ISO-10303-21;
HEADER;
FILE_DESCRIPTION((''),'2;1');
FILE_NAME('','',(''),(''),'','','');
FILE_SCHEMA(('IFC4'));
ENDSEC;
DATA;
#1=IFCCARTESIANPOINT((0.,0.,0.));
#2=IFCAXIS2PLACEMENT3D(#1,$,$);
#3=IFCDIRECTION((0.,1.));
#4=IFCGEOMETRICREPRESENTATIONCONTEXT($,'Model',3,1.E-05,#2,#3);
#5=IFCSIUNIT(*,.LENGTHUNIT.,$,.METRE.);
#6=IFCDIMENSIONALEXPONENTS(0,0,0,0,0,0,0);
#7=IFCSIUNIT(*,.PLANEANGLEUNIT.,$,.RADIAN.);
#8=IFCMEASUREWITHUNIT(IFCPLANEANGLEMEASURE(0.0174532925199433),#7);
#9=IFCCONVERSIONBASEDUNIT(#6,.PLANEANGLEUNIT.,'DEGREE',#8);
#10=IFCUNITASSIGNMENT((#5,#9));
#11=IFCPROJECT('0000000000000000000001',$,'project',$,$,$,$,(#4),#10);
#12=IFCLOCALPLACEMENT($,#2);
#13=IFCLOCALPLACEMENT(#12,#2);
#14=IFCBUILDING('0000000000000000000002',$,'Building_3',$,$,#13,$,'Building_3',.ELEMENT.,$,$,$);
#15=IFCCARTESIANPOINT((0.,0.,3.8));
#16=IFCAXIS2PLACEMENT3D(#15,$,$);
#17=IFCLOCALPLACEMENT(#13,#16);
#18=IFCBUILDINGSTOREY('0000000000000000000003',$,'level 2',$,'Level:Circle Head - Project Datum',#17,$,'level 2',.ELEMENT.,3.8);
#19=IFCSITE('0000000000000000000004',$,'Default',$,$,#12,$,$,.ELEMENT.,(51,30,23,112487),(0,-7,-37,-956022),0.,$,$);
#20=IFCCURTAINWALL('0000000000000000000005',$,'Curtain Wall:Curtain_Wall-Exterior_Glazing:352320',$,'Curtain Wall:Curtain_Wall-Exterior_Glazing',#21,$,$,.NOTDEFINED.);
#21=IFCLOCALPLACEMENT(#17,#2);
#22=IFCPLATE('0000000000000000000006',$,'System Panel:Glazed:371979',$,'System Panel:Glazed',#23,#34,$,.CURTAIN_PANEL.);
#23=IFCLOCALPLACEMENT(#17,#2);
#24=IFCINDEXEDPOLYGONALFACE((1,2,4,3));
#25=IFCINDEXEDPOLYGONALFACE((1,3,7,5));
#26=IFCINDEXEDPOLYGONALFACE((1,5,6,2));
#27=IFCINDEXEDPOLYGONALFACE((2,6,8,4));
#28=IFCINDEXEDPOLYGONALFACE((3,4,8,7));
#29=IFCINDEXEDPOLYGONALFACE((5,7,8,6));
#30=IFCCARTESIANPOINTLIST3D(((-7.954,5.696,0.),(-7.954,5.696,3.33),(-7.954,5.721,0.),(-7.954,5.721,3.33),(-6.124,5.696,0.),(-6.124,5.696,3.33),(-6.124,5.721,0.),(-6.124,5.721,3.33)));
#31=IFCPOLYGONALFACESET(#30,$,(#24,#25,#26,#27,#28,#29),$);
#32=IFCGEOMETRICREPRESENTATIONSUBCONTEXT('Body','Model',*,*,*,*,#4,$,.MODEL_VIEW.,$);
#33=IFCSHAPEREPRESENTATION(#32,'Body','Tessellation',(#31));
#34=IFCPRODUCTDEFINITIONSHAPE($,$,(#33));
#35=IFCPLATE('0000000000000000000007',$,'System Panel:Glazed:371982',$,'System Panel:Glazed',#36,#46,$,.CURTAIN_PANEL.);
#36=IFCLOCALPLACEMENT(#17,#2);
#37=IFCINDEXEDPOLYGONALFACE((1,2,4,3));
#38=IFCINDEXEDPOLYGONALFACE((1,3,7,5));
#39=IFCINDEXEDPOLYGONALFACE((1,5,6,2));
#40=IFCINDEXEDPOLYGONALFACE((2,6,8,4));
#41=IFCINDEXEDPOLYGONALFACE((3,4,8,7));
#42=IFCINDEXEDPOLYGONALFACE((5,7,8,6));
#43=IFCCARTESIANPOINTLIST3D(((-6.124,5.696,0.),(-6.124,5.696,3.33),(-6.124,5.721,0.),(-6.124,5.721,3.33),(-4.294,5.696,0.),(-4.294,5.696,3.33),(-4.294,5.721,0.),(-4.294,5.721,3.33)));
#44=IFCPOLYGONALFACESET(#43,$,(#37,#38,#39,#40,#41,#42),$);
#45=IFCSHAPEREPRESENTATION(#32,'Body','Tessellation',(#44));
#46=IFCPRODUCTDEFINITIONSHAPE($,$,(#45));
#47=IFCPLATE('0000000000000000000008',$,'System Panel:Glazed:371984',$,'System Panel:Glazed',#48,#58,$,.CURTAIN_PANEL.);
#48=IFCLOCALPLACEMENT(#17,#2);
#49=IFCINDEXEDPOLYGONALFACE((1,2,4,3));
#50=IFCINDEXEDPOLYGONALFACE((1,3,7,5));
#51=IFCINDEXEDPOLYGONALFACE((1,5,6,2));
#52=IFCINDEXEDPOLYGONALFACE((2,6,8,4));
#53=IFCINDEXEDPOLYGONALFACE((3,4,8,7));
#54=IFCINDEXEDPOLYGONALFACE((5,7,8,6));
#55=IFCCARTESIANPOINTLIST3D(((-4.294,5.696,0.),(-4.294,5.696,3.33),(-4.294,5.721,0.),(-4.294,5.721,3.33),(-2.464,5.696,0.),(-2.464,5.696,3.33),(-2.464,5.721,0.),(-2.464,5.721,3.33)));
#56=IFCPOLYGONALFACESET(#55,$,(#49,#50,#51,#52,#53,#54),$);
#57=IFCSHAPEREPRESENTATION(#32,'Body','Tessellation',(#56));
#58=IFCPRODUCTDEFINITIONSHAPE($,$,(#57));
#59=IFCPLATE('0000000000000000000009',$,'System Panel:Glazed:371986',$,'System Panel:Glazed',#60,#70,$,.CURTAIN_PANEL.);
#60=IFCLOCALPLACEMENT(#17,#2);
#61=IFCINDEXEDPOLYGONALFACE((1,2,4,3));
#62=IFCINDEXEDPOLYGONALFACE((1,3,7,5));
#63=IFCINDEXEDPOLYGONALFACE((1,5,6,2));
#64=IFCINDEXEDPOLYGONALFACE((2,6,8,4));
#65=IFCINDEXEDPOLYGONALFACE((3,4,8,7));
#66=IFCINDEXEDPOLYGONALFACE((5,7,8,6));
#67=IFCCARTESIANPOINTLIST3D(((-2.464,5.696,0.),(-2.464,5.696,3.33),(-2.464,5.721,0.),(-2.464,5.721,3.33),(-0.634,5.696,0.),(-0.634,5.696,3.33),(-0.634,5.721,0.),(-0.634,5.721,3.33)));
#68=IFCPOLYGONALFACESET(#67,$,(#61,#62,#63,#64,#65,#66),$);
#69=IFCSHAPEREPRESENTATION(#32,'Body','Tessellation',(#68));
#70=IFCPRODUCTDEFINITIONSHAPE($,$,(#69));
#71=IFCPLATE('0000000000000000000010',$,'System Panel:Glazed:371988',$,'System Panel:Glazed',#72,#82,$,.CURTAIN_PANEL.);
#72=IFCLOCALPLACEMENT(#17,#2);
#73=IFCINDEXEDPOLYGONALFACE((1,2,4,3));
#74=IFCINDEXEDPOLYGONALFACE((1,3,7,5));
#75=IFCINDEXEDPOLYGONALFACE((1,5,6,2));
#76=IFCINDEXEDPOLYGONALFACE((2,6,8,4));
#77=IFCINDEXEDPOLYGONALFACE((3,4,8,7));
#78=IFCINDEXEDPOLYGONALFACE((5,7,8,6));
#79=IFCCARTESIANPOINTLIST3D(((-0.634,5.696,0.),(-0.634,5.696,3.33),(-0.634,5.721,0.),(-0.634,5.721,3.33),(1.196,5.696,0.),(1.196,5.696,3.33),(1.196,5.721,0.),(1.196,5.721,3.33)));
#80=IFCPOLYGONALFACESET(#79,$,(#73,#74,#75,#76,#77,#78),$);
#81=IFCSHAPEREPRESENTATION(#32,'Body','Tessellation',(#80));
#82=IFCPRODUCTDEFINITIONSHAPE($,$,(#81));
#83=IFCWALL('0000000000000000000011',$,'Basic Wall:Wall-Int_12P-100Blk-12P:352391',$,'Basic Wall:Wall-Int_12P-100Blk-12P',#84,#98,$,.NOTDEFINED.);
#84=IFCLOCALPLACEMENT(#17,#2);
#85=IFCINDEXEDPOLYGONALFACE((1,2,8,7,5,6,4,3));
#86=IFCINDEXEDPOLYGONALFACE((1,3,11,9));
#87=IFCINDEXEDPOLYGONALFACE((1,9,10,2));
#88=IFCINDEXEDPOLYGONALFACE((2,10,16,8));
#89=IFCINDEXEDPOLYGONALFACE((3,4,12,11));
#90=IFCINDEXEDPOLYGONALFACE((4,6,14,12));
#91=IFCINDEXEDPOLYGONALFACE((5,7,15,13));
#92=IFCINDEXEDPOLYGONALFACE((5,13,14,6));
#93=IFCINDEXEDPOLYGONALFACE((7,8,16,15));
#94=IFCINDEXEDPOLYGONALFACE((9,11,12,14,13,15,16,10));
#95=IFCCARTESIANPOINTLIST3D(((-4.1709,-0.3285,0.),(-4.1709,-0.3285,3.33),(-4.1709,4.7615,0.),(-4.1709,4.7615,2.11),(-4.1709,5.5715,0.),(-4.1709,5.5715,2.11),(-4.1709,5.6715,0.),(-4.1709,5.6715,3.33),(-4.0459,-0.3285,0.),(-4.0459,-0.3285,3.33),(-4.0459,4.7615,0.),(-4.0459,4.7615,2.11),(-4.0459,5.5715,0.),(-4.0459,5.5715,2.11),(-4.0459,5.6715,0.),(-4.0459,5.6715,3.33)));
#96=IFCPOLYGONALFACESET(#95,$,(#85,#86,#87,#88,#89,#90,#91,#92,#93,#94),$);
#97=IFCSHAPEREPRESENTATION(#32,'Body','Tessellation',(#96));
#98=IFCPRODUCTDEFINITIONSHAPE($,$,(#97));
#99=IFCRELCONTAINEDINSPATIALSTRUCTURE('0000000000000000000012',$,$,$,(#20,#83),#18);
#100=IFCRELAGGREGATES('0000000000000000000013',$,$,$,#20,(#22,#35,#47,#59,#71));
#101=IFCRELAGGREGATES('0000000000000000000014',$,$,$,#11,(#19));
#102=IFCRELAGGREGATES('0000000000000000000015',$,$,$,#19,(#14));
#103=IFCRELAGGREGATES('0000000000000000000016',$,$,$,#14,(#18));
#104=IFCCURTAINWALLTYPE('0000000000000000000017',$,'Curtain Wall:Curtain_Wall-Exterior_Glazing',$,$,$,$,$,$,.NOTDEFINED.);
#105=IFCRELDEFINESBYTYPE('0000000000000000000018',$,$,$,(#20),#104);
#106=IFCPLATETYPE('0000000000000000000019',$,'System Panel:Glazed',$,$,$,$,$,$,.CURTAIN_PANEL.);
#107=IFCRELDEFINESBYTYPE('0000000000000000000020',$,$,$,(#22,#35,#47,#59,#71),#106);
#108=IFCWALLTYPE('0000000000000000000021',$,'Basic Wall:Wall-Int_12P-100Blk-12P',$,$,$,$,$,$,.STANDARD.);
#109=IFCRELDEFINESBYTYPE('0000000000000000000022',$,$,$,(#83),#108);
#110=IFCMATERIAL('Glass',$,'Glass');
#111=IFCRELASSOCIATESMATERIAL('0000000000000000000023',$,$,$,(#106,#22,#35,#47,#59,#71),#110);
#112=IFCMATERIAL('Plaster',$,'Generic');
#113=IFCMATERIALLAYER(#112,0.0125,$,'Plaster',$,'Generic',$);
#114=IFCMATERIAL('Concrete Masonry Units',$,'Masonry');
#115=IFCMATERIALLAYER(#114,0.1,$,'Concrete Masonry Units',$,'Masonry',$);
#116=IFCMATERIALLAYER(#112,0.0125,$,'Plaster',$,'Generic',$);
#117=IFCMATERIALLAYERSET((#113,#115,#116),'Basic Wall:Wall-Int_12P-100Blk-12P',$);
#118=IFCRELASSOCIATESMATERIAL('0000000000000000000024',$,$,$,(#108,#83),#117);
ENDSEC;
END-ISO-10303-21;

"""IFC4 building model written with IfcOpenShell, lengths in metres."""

from ifc_helpers import new_model, entity, si_unit, converted_unit, direction, frame, frame_2d, origin, origin_2d_with_axis, place, context, subcontext, project, spatial, polyline, rectangle, extrude, clip, bounded_halfspace, source, transform, mapped, material, layer, layer_set, layer_usage, type_object, type_shapes, element, aggregate, save


model = new_model("IFC4")

# Units and contexts
model_context = context("Model", 3, precision=1e-05, world=origin(), true_north=direction((0.0, 1.0)))
body_context = subcontext(model_context, "Body", "Model", "MODEL_VIEW")
ifc_project = project(units=[si_unit("LENGTHUNIT", "METRE"), converted_unit("PLANEANGLEUNIT", "DEGREE", entity("IfcPlaneAngleMeasure", 0.0174532925199433), si_unit("PLANEANGLEUNIT", "RADIAN"), dimensions=[0, 0, 0, 0, 0, 0, 0])], contexts=[model_context])

# Site, building, storey
site_placement = place(None, origin())
site = spatial("IfcSite", under=ifc_project, at=site_placement, Name="Default", CompositionType="ELEMENT", RefLatitude=(51, 30, 23, 112487), RefLongitude=(0, -7, -37, -956022), RefElevation=0.0)
building_placement = place(site_placement, origin())
building = spatial("IfcBuilding", under=site, at=building_placement, Name="Building_3", LongName="Building_3", CompositionType="ELEMENT")
storey_placement = place(building_placement, frame((0.0, 0.0, 3.8)))
storey = spatial("IfcBuildingStorey", under=building, at=storey_placement, Name="level 2", ObjectType="Level:Circle Head - Project Datum", LongName="level 2", CompositionType="ELEMENT", Elevation=3.8)

# Curtain wall, plates
curtain_wall_type = type_object("IfcCurtainWallType", Name="Curtain Wall:Curtain_Wall-Exterior_Glazing", PredefinedType="NOTDEFINED")
curtain_wall_placement = place(storey_placement, frame((0.0, 0.0, -3.8)))
curtain_wall = element("IfcCurtainWall", 1, at=curtain_wall_placement, inside=storey, type_object=curtain_wall_type, Name="Curtain Wall:Curtain_Wall-Exterior_Glazing:352320", ObjectType="Curtain Wall:Curtain_Wall-Exterior_Glazing", PredefinedType="NOTDEFINED")
ifc_material_1 = material(Name="Glass", Category="Glass")
plate_type = type_object("IfcPlateType", Name="System Panel:Glazed", PredefinedType="CURTAIN_PANEL", material=ifc_material_1)
shared_shape_1 = source(origin(), body_context, "Body", "SweptSolid", [
    extrude(rectangle(XDim=0.025, YDim=1.83, at=origin_2d_with_axis()), frame((0.915, 0.0125, 0.0), z_axis=(0.0, 0.0, 1.0), x_axis=(0.0, 1.0, 0.0)), (0.0, 0.0, 1.0), 3.33),
])
type_shapes(plate_type, [shared_shape_1])
plate_1_placement = place(curtain_wall_placement, frame((-7.954, 5.696, 3.8)))
plate_1 = element("IfcPlate", 2, at=plate_1_placement, type_object=plate_type, material=ifc_material_1, Name="System Panel:Glazed:371979", ObjectType="System Panel:Glazed", PredefinedType="CURTAIN_PANEL", context=body_context, shape_type="MappedRepresentation", body=[
    mapped(shared_shape_1, transform((0.0, 0.0, 0.0), scale=1.0)),
])
plate_2_placement = place(curtain_wall_placement, frame((-6.124, 5.696, 3.8)))
plate_2 = element("IfcPlate", 3, at=plate_2_placement, type_object=plate_type, material=ifc_material_1, Name="System Panel:Glazed:371982", ObjectType="System Panel:Glazed", PredefinedType="CURTAIN_PANEL", context=body_context, shape_type="MappedRepresentation", body=[
    mapped(shared_shape_1, transform((0.0, 0.0, 0.0), scale=1.0)),
])
plate_3_placement = place(curtain_wall_placement, frame((-4.294, 5.696, 3.8)))
plate_3 = element("IfcPlate", 4, at=plate_3_placement, type_object=plate_type, material=ifc_material_1, Name="System Panel:Glazed:371984", ObjectType="System Panel:Glazed", PredefinedType="CURTAIN_PANEL", context=body_context, shape_type="MappedRepresentation", body=[
    mapped(shared_shape_1, transform((0.0, 0.0, 0.0), scale=1.0)),
])
plate_4_placement = place(curtain_wall_placement, frame((-2.464, 5.696, 3.8)))
plate_4 = element("IfcPlate", 5, at=plate_4_placement, type_object=plate_type, material=ifc_material_1, Name="System Panel:Glazed:371986", ObjectType="System Panel:Glazed", PredefinedType="CURTAIN_PANEL", context=body_context, shape_type="MappedRepresentation", body=[
    mapped(shared_shape_1, transform((0.0, 0.0, 0.0), scale=1.0)),
])
plate_5_placement = place(curtain_wall_placement, frame((-0.634, 5.696, 3.8)))
plate_5 = element("IfcPlate", 6, at=plate_5_placement, type_object=plate_type, material=ifc_material_1, Name="System Panel:Glazed:371988", ObjectType="System Panel:Glazed", PredefinedType="CURTAIN_PANEL", context=body_context, shape_type="MappedRepresentation", body=[
    mapped(shared_shape_1, transform((0.0, 0.0, 0.0), scale=1.0)),
])
aggregate(curtain_wall, [plate_1, plate_2, plate_3, plate_4, plate_5])

# Wall, opening
ifc_material_2 = material(Name="Plaster", Category="Generic")
ifc_layer_1 = layer(ifc_material_2, 0.0125, Name="Plaster", Category="Generic")
ifc_material_3 = material(Name="Concrete Masonry Units", Category="Masonry")
ifc_layer_2 = layer(ifc_material_3, 0.1, Name="Concrete Masonry Units", Category="Masonry")
ifc_layer_3 = layer(ifc_material_2, 0.0125, Name="Plaster", Category="Generic")
ifc_layer_set_1 = layer_set([ifc_layer_1, ifc_layer_2, ifc_layer_3], Name="Basic Wall:Wall-Int_12P-100Blk-12P")
ifc_layer_usage_1 = layer_usage(ifc_layer_set_1, "AXIS2", "NEGATIVE", 0.0625)
wall_type = type_object("IfcWallType", Name="Basic Wall:Wall-Int_12P-100Blk-12P", PredefinedType="STANDARD", material=ifc_layer_set_1)
wall_placement = place(storey_placement, frame((-4.1084, 5.6715, 0.0), z_axis=(0.0, 0.0, 1.0), x_axis=(0.0, -1.0, 0.0)))
wall = element("IfcWall", 7, at=wall_placement, inside=storey, type_object=wall_type, material=ifc_layer_usage_1, Name="Basic Wall:Wall-Int_12P-100Blk-12P:352391", ObjectType="Basic Wall:Wall-Int_12P-100Blk-12P", PredefinedType="NOTDEFINED", context=body_context, shape_type="Clipping", body=[
    clip(extrude(rectangle(XDim=6.0, YDim=0.125, at=frame_2d((3.0, 0.0), x_axis=(1.0, 0.0))), origin(), (0.0, 0.0, 1.0), 3.33), bounded_halfspace(frame((0.0, -0.0625, 3.33), z_axis=(0.0, 0.0, -1.0), x_axis=(-1.0, 0.0, 0.0)), True, frame((0.0, -0.0625, 3.33)), polyline([(0.0, 0.0), (6.0, 0.0), (6.0, 0.125), (0.0, 0.125), (0.0, 0.0)]))),
])
opening_1_placement = place(wall_placement, frame((0.1, -0.0625, 0.0)))
element("IfcOpeningElement", 8, at=opening_1_placement, cuts=wall, PredefinedType="OPENING", context=body_context, shape_type="SweptSolid", body=[
    extrude(rectangle(XDim=2.11, YDim=0.81, at=frame_2d((1.055, 0.405), x_axis=(1.0, 0.0))), frame((0.0, 0.0, 0.0), z_axis=(0.0, 1.0, 0.0), x_axis=(0.0, 0.0, 1.0)), (0.0, 0.0, 1.0), 0.125),
])

save(model, "model.ifc")
